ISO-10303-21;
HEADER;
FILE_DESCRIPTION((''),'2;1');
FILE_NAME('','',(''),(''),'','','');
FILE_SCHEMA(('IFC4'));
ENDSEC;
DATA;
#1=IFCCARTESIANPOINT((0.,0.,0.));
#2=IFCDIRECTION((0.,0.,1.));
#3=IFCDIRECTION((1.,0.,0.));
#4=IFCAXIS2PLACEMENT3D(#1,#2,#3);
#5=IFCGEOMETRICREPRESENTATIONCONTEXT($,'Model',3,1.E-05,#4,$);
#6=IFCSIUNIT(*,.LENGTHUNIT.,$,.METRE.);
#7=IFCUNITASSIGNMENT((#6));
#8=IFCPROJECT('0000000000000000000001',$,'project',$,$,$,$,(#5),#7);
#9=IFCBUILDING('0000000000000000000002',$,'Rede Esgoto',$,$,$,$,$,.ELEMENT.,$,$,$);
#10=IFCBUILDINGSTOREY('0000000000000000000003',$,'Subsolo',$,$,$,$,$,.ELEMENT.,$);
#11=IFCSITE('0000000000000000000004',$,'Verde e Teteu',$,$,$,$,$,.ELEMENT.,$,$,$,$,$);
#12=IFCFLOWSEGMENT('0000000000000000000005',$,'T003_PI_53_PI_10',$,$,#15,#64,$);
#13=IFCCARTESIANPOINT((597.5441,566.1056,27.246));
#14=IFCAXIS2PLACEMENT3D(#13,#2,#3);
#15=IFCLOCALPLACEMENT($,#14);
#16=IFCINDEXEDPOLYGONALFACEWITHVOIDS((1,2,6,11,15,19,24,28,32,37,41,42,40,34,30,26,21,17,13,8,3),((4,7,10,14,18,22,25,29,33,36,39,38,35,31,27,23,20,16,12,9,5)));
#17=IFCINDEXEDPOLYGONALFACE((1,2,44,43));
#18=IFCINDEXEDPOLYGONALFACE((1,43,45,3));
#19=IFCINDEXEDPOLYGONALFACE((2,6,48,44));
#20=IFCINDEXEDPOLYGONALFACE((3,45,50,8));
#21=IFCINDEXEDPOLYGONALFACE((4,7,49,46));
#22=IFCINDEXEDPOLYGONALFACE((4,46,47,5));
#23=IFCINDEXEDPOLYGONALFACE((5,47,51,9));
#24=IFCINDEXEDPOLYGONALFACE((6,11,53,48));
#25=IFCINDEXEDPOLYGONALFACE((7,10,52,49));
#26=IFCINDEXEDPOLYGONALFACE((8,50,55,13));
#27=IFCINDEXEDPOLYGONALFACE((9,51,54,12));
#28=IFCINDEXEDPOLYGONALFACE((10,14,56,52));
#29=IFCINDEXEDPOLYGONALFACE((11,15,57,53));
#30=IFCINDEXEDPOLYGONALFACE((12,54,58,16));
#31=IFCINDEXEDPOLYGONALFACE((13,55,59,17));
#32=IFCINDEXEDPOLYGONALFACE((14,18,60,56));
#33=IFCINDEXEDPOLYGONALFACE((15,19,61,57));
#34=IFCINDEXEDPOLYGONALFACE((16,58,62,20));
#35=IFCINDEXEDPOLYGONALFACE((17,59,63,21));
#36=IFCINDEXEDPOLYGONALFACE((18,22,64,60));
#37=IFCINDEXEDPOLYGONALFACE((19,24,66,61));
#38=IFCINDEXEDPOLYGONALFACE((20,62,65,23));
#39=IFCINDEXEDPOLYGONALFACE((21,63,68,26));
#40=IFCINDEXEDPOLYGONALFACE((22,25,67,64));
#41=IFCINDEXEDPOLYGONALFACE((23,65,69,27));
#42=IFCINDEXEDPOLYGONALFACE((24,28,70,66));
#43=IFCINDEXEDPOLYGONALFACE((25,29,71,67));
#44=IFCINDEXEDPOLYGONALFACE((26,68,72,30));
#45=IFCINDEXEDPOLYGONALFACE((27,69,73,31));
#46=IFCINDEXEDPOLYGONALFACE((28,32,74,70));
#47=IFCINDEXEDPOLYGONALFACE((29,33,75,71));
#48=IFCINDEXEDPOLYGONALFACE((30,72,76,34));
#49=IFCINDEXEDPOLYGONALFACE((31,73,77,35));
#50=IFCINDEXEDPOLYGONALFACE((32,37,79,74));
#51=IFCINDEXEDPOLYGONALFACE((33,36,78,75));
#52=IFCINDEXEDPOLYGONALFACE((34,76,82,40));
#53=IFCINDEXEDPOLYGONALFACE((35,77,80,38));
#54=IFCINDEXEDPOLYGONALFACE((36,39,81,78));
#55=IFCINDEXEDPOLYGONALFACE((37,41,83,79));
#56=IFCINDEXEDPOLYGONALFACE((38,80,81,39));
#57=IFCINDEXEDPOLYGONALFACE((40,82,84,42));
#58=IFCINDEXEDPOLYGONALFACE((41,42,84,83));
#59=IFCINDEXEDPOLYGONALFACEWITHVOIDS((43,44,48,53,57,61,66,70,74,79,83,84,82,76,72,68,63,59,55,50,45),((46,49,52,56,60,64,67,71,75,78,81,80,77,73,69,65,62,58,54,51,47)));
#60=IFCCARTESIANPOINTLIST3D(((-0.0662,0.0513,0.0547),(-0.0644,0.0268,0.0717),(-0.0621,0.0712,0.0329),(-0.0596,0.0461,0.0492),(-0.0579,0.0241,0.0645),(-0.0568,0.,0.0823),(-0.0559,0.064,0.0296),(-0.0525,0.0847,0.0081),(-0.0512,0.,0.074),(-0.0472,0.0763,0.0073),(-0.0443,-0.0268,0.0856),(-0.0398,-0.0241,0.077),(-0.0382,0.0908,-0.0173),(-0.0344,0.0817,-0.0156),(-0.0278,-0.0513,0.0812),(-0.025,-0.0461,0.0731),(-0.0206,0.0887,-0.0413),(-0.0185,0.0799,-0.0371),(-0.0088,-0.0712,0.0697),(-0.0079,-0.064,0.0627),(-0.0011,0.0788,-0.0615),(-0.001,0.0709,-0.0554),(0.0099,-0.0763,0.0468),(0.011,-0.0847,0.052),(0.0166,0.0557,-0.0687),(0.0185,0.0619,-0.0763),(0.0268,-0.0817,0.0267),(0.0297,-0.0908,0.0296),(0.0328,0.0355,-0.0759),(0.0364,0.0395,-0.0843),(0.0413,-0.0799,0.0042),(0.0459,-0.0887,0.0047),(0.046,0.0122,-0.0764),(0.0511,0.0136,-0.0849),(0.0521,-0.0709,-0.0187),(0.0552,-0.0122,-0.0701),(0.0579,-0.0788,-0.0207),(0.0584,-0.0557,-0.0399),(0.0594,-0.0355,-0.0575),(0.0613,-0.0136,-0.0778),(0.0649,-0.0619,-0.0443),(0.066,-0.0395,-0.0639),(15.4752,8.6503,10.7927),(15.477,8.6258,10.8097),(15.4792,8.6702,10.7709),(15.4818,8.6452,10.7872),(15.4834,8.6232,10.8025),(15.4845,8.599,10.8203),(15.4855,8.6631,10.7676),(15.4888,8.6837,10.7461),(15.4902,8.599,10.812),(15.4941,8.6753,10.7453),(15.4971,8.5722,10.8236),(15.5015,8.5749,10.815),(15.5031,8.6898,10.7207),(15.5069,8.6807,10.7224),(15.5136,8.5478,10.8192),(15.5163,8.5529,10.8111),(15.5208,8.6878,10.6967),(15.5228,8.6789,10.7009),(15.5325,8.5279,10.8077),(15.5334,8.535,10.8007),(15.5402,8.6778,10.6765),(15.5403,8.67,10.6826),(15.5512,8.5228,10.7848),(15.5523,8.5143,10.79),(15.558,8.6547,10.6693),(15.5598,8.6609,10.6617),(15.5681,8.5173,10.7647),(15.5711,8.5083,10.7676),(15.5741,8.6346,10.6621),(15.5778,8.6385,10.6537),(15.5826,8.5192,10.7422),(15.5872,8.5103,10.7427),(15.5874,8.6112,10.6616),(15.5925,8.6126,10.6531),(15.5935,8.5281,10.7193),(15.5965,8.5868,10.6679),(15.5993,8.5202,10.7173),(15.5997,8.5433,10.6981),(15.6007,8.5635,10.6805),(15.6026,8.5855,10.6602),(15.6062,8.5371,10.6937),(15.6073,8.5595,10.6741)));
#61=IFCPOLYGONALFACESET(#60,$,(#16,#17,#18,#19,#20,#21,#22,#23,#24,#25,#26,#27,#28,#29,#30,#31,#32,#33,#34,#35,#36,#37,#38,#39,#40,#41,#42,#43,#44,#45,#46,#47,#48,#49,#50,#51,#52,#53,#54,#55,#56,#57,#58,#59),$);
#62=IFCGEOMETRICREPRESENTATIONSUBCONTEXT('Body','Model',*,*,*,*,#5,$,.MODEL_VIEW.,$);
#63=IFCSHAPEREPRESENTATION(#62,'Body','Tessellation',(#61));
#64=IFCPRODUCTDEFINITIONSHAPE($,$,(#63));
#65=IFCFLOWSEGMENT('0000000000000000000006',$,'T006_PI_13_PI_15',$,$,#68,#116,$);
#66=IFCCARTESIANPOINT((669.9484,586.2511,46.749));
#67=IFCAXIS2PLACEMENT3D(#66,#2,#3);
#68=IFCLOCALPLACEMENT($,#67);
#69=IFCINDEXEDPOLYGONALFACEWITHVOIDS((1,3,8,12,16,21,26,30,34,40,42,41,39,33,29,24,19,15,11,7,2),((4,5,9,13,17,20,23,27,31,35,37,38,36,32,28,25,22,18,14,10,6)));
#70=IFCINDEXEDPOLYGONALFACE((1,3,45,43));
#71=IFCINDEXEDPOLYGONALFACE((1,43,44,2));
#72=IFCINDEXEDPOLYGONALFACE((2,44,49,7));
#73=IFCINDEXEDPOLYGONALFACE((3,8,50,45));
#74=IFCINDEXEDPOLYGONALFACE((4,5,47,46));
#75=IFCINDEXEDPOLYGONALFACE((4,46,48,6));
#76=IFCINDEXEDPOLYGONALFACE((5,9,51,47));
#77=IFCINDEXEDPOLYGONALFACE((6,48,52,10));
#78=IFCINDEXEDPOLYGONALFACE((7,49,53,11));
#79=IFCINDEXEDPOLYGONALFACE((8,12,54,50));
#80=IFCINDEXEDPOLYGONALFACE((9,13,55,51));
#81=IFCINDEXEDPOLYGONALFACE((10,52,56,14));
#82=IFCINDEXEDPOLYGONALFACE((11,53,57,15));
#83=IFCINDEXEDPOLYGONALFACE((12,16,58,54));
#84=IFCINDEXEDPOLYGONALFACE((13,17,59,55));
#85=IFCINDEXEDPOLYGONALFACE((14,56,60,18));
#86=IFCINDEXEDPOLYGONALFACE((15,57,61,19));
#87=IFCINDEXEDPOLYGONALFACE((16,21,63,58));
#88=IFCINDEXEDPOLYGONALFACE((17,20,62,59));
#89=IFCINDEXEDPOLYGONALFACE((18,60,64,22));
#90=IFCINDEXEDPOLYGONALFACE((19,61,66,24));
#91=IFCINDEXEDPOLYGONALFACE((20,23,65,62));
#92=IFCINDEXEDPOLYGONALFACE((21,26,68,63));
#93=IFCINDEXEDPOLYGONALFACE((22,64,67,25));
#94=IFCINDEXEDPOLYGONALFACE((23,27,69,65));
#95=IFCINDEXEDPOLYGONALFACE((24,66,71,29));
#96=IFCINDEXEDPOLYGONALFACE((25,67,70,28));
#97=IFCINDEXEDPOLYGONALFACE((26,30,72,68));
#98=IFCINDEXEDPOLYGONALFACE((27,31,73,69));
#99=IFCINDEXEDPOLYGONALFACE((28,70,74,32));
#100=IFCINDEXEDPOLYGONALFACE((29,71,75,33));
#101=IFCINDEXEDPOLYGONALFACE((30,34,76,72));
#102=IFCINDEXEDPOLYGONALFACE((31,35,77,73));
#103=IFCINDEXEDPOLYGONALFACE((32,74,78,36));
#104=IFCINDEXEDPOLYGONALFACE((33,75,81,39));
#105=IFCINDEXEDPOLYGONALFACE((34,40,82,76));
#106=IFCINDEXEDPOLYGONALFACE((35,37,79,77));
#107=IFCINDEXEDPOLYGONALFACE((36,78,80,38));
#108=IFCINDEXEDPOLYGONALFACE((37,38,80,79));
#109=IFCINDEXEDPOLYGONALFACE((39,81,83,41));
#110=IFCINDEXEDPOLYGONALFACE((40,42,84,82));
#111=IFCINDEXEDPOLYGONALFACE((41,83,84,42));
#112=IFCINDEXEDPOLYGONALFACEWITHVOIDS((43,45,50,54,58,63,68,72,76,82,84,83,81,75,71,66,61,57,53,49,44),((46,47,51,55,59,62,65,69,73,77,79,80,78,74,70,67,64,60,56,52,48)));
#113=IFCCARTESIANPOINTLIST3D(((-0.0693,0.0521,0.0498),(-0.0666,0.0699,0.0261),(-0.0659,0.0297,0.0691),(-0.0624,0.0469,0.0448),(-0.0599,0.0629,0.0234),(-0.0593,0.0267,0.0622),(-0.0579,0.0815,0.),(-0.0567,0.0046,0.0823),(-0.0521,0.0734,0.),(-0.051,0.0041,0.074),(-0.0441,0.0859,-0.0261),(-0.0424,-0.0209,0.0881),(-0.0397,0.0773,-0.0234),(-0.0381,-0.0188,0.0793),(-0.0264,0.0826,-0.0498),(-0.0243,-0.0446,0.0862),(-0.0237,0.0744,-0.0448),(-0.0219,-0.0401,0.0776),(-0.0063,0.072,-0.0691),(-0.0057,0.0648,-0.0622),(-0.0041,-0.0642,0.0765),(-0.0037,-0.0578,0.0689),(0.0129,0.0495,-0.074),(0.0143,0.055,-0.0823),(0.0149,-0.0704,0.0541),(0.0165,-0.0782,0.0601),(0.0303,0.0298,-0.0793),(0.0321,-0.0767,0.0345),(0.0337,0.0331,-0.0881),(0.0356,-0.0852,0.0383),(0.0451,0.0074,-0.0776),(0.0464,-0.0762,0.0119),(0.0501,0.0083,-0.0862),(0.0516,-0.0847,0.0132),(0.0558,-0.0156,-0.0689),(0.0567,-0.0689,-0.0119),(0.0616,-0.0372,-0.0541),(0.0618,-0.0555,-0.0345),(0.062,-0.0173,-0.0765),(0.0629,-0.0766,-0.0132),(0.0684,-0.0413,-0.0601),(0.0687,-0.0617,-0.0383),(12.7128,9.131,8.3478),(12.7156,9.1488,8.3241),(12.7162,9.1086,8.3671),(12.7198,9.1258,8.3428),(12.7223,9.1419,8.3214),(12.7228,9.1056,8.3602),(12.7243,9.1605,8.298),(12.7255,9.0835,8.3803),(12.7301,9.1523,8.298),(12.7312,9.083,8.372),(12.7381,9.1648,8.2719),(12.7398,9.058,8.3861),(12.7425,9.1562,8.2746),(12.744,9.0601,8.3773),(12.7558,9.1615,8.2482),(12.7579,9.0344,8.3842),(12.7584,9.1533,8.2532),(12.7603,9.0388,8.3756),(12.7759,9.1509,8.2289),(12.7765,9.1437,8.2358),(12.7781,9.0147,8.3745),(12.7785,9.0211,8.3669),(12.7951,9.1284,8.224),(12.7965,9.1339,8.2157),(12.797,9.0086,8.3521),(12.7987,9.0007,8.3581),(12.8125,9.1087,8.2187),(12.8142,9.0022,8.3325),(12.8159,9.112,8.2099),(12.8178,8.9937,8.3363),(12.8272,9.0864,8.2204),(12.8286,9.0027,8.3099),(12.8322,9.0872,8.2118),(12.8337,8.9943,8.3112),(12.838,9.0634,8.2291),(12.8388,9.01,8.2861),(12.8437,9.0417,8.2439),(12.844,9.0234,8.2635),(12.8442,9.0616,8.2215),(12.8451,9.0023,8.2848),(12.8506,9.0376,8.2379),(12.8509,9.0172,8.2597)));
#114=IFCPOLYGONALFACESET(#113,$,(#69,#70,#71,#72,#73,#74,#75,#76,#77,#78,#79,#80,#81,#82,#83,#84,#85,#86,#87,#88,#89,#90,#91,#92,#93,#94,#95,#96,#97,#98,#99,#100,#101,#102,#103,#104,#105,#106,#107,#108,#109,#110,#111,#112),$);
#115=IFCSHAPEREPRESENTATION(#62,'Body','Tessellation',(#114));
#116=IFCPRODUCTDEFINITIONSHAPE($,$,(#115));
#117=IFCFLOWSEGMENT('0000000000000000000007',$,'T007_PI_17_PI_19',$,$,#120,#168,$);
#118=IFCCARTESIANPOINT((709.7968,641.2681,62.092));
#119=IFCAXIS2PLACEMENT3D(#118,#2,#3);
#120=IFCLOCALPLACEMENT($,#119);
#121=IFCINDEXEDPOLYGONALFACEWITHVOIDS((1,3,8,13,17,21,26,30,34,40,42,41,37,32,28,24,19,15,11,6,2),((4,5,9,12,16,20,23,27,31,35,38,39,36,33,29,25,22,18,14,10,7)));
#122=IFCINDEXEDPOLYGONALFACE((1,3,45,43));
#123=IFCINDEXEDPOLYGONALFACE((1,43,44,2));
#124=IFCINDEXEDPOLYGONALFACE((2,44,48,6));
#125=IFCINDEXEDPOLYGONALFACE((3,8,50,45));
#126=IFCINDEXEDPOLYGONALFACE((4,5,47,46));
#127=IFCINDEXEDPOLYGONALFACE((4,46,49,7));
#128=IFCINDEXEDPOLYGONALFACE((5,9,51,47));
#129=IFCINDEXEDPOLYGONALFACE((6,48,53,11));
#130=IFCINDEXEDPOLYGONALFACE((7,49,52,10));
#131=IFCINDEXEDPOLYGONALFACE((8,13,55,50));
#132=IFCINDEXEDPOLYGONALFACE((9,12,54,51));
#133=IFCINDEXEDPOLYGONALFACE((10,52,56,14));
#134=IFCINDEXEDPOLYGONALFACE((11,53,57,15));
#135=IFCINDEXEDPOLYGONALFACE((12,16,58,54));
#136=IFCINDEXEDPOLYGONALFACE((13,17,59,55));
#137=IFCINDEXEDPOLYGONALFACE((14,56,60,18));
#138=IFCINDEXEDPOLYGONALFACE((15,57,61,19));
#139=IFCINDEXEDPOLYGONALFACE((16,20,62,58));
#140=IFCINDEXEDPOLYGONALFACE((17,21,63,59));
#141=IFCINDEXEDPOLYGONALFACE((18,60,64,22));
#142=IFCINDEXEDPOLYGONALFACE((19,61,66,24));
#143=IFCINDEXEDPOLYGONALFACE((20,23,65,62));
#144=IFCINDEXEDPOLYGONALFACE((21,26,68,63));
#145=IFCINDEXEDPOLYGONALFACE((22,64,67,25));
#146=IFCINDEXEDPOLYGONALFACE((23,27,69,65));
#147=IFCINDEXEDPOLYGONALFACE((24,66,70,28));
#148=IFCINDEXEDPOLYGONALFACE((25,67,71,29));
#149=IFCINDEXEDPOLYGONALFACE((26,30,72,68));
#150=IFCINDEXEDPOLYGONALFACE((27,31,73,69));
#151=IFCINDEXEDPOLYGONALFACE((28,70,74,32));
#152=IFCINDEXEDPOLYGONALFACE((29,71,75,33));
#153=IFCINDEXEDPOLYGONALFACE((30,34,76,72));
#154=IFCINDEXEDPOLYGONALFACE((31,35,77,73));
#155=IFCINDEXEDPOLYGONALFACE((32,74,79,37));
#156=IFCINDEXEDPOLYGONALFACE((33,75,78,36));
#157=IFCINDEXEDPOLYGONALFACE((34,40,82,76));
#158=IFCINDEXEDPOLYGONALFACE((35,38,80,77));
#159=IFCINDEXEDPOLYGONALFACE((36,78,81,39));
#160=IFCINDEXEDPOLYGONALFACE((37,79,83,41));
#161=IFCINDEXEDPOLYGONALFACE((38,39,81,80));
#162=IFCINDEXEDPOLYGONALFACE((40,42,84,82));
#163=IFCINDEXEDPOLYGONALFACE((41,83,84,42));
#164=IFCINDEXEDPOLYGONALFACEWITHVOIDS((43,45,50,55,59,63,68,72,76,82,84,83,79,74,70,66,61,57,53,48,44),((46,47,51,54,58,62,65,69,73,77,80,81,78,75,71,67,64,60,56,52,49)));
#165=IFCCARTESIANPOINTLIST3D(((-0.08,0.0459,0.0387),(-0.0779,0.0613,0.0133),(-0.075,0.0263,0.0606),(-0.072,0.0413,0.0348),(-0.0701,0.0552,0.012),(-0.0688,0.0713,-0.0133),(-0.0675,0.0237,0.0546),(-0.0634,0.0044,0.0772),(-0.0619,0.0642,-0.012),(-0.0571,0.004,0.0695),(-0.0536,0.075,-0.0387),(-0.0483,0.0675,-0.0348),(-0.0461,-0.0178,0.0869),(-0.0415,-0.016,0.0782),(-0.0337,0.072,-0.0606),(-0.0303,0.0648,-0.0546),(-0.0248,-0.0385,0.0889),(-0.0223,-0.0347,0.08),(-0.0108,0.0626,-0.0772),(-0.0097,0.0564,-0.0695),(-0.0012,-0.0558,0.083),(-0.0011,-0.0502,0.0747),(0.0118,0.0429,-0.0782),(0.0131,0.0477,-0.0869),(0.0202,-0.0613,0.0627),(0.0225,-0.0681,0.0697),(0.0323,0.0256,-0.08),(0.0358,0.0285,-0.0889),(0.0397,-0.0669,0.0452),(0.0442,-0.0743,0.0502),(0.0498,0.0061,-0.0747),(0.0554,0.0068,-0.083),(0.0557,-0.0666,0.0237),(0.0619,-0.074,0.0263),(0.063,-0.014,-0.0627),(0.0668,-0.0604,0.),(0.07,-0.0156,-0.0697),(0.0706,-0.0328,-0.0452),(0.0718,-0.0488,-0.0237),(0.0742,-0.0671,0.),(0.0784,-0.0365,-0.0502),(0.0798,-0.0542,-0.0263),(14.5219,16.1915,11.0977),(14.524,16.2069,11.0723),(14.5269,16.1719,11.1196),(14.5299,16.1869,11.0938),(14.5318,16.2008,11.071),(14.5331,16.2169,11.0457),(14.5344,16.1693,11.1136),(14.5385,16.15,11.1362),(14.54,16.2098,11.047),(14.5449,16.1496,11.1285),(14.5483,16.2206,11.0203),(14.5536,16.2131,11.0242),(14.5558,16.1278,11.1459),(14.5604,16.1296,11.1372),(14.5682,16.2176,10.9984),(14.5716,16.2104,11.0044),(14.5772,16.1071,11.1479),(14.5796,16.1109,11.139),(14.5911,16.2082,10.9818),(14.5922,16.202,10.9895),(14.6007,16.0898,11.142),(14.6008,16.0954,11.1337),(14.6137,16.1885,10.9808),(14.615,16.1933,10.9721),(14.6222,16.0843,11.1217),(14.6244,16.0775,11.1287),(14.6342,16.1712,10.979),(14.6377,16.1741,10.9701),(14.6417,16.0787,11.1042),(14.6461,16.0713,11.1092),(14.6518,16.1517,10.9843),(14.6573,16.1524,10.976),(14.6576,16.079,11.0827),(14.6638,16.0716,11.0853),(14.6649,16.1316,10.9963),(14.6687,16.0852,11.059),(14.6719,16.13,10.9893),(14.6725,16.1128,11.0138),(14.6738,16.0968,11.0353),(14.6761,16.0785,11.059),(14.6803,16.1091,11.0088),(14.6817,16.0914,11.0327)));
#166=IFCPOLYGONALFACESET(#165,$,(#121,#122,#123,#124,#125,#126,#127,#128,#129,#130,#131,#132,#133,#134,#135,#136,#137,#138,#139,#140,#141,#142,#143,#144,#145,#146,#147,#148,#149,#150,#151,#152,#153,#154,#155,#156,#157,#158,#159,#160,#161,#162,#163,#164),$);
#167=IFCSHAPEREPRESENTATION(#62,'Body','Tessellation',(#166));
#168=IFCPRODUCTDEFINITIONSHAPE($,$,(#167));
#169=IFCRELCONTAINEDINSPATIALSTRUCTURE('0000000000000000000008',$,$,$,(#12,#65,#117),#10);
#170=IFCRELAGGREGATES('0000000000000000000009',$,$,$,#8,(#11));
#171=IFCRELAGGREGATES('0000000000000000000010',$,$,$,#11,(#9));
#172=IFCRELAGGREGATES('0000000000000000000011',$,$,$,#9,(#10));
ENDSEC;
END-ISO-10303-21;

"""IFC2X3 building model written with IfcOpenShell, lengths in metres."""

from ifc_helpers import new_model, entity, si_unit, frame, origin_with_axes, place, context, subcontext, project, spatial, element, save


model = new_model("IFC2X3")

# Units and contexts
model_context = context("Model", 3, precision=1e-05, world=origin_with_axes())
body_context = subcontext(model_context, "Body", "Model", "MODEL_VIEW")
ifc_project = project(units=[si_unit("LENGTHUNIT", "METRE")], contexts=[model_context])

# Site, building, storey
site = spatial("IfcSite", under=ifc_project, Name="Verde e Teteu", CompositionType="ELEMENT")
building = spatial("IfcBuilding", under=site, Name="Rede Esgoto", CompositionType="ELEMENT")
storey = spatial("IfcBuildingStorey", under=building, Name="Subsolo", CompositionType="ELEMENT")

# Flow segments
flow_segment_1_placement = place(None, frame((597.5441, 566.1056, 27.246), z_axis=(0.0, 0.0, 1.0), x_axis=(1.0, 0.0, 0.0)))
element("IfcFlowSegment", 1, at=flow_segment_1_placement, inside=storey, Name="T003_PI_53_PI_10", context=body_context, shape_type="SweptSolid", body=[
    entity("IfcSweptDiskSolid", entity("IfcPolyline", [entity("IfcCartesianPoint", [0.0, 0.0, 0.0]), entity("IfcCartesianPoint", [15.5413, 8.599, 10.738])]), 0.1, 0.09),
])
flow_segment_2_placement = place(None, frame((669.9484, 586.2511, 46.749), z_axis=(0.0, 0.0, 1.0), x_axis=(1.0, 0.0, 0.0)))
element("IfcFlowSegment", 2, at=flow_segment_2_placement, inside=storey, Name="T006_PI_13_PI_15", context=body_context, shape_type="SweptSolid", body=[
    entity("IfcSweptDiskSolid", entity("IfcPolyline", [entity("IfcCartesianPoint", [0.0, 0.0, 0.0]), entity("IfcCartesianPoint", [12.7822, 9.0789, 8.298])]), 0.1, 0.09),
])
flow_segment_3_placement = place(None, frame((709.7968, 641.2681, 62.092), z_axis=(0.0, 0.0, 1.0), x_axis=(1.0, 0.0, 0.0)))
element("IfcFlowSegment", 3, at=flow_segment_3_placement, inside=storey, Name="T007_PI_17_PI_19", context=body_context, shape_type="SweptSolid", body=[
    entity("IfcSweptDiskSolid", entity("IfcPolyline", [entity("IfcCartesianPoint", [0.0, 0.0, 0.0]), entity("IfcCartesianPoint", [14.6019, 16.1456, 11.059])]), 0.1, 0.09),
])

save(model, "model.ifc")
